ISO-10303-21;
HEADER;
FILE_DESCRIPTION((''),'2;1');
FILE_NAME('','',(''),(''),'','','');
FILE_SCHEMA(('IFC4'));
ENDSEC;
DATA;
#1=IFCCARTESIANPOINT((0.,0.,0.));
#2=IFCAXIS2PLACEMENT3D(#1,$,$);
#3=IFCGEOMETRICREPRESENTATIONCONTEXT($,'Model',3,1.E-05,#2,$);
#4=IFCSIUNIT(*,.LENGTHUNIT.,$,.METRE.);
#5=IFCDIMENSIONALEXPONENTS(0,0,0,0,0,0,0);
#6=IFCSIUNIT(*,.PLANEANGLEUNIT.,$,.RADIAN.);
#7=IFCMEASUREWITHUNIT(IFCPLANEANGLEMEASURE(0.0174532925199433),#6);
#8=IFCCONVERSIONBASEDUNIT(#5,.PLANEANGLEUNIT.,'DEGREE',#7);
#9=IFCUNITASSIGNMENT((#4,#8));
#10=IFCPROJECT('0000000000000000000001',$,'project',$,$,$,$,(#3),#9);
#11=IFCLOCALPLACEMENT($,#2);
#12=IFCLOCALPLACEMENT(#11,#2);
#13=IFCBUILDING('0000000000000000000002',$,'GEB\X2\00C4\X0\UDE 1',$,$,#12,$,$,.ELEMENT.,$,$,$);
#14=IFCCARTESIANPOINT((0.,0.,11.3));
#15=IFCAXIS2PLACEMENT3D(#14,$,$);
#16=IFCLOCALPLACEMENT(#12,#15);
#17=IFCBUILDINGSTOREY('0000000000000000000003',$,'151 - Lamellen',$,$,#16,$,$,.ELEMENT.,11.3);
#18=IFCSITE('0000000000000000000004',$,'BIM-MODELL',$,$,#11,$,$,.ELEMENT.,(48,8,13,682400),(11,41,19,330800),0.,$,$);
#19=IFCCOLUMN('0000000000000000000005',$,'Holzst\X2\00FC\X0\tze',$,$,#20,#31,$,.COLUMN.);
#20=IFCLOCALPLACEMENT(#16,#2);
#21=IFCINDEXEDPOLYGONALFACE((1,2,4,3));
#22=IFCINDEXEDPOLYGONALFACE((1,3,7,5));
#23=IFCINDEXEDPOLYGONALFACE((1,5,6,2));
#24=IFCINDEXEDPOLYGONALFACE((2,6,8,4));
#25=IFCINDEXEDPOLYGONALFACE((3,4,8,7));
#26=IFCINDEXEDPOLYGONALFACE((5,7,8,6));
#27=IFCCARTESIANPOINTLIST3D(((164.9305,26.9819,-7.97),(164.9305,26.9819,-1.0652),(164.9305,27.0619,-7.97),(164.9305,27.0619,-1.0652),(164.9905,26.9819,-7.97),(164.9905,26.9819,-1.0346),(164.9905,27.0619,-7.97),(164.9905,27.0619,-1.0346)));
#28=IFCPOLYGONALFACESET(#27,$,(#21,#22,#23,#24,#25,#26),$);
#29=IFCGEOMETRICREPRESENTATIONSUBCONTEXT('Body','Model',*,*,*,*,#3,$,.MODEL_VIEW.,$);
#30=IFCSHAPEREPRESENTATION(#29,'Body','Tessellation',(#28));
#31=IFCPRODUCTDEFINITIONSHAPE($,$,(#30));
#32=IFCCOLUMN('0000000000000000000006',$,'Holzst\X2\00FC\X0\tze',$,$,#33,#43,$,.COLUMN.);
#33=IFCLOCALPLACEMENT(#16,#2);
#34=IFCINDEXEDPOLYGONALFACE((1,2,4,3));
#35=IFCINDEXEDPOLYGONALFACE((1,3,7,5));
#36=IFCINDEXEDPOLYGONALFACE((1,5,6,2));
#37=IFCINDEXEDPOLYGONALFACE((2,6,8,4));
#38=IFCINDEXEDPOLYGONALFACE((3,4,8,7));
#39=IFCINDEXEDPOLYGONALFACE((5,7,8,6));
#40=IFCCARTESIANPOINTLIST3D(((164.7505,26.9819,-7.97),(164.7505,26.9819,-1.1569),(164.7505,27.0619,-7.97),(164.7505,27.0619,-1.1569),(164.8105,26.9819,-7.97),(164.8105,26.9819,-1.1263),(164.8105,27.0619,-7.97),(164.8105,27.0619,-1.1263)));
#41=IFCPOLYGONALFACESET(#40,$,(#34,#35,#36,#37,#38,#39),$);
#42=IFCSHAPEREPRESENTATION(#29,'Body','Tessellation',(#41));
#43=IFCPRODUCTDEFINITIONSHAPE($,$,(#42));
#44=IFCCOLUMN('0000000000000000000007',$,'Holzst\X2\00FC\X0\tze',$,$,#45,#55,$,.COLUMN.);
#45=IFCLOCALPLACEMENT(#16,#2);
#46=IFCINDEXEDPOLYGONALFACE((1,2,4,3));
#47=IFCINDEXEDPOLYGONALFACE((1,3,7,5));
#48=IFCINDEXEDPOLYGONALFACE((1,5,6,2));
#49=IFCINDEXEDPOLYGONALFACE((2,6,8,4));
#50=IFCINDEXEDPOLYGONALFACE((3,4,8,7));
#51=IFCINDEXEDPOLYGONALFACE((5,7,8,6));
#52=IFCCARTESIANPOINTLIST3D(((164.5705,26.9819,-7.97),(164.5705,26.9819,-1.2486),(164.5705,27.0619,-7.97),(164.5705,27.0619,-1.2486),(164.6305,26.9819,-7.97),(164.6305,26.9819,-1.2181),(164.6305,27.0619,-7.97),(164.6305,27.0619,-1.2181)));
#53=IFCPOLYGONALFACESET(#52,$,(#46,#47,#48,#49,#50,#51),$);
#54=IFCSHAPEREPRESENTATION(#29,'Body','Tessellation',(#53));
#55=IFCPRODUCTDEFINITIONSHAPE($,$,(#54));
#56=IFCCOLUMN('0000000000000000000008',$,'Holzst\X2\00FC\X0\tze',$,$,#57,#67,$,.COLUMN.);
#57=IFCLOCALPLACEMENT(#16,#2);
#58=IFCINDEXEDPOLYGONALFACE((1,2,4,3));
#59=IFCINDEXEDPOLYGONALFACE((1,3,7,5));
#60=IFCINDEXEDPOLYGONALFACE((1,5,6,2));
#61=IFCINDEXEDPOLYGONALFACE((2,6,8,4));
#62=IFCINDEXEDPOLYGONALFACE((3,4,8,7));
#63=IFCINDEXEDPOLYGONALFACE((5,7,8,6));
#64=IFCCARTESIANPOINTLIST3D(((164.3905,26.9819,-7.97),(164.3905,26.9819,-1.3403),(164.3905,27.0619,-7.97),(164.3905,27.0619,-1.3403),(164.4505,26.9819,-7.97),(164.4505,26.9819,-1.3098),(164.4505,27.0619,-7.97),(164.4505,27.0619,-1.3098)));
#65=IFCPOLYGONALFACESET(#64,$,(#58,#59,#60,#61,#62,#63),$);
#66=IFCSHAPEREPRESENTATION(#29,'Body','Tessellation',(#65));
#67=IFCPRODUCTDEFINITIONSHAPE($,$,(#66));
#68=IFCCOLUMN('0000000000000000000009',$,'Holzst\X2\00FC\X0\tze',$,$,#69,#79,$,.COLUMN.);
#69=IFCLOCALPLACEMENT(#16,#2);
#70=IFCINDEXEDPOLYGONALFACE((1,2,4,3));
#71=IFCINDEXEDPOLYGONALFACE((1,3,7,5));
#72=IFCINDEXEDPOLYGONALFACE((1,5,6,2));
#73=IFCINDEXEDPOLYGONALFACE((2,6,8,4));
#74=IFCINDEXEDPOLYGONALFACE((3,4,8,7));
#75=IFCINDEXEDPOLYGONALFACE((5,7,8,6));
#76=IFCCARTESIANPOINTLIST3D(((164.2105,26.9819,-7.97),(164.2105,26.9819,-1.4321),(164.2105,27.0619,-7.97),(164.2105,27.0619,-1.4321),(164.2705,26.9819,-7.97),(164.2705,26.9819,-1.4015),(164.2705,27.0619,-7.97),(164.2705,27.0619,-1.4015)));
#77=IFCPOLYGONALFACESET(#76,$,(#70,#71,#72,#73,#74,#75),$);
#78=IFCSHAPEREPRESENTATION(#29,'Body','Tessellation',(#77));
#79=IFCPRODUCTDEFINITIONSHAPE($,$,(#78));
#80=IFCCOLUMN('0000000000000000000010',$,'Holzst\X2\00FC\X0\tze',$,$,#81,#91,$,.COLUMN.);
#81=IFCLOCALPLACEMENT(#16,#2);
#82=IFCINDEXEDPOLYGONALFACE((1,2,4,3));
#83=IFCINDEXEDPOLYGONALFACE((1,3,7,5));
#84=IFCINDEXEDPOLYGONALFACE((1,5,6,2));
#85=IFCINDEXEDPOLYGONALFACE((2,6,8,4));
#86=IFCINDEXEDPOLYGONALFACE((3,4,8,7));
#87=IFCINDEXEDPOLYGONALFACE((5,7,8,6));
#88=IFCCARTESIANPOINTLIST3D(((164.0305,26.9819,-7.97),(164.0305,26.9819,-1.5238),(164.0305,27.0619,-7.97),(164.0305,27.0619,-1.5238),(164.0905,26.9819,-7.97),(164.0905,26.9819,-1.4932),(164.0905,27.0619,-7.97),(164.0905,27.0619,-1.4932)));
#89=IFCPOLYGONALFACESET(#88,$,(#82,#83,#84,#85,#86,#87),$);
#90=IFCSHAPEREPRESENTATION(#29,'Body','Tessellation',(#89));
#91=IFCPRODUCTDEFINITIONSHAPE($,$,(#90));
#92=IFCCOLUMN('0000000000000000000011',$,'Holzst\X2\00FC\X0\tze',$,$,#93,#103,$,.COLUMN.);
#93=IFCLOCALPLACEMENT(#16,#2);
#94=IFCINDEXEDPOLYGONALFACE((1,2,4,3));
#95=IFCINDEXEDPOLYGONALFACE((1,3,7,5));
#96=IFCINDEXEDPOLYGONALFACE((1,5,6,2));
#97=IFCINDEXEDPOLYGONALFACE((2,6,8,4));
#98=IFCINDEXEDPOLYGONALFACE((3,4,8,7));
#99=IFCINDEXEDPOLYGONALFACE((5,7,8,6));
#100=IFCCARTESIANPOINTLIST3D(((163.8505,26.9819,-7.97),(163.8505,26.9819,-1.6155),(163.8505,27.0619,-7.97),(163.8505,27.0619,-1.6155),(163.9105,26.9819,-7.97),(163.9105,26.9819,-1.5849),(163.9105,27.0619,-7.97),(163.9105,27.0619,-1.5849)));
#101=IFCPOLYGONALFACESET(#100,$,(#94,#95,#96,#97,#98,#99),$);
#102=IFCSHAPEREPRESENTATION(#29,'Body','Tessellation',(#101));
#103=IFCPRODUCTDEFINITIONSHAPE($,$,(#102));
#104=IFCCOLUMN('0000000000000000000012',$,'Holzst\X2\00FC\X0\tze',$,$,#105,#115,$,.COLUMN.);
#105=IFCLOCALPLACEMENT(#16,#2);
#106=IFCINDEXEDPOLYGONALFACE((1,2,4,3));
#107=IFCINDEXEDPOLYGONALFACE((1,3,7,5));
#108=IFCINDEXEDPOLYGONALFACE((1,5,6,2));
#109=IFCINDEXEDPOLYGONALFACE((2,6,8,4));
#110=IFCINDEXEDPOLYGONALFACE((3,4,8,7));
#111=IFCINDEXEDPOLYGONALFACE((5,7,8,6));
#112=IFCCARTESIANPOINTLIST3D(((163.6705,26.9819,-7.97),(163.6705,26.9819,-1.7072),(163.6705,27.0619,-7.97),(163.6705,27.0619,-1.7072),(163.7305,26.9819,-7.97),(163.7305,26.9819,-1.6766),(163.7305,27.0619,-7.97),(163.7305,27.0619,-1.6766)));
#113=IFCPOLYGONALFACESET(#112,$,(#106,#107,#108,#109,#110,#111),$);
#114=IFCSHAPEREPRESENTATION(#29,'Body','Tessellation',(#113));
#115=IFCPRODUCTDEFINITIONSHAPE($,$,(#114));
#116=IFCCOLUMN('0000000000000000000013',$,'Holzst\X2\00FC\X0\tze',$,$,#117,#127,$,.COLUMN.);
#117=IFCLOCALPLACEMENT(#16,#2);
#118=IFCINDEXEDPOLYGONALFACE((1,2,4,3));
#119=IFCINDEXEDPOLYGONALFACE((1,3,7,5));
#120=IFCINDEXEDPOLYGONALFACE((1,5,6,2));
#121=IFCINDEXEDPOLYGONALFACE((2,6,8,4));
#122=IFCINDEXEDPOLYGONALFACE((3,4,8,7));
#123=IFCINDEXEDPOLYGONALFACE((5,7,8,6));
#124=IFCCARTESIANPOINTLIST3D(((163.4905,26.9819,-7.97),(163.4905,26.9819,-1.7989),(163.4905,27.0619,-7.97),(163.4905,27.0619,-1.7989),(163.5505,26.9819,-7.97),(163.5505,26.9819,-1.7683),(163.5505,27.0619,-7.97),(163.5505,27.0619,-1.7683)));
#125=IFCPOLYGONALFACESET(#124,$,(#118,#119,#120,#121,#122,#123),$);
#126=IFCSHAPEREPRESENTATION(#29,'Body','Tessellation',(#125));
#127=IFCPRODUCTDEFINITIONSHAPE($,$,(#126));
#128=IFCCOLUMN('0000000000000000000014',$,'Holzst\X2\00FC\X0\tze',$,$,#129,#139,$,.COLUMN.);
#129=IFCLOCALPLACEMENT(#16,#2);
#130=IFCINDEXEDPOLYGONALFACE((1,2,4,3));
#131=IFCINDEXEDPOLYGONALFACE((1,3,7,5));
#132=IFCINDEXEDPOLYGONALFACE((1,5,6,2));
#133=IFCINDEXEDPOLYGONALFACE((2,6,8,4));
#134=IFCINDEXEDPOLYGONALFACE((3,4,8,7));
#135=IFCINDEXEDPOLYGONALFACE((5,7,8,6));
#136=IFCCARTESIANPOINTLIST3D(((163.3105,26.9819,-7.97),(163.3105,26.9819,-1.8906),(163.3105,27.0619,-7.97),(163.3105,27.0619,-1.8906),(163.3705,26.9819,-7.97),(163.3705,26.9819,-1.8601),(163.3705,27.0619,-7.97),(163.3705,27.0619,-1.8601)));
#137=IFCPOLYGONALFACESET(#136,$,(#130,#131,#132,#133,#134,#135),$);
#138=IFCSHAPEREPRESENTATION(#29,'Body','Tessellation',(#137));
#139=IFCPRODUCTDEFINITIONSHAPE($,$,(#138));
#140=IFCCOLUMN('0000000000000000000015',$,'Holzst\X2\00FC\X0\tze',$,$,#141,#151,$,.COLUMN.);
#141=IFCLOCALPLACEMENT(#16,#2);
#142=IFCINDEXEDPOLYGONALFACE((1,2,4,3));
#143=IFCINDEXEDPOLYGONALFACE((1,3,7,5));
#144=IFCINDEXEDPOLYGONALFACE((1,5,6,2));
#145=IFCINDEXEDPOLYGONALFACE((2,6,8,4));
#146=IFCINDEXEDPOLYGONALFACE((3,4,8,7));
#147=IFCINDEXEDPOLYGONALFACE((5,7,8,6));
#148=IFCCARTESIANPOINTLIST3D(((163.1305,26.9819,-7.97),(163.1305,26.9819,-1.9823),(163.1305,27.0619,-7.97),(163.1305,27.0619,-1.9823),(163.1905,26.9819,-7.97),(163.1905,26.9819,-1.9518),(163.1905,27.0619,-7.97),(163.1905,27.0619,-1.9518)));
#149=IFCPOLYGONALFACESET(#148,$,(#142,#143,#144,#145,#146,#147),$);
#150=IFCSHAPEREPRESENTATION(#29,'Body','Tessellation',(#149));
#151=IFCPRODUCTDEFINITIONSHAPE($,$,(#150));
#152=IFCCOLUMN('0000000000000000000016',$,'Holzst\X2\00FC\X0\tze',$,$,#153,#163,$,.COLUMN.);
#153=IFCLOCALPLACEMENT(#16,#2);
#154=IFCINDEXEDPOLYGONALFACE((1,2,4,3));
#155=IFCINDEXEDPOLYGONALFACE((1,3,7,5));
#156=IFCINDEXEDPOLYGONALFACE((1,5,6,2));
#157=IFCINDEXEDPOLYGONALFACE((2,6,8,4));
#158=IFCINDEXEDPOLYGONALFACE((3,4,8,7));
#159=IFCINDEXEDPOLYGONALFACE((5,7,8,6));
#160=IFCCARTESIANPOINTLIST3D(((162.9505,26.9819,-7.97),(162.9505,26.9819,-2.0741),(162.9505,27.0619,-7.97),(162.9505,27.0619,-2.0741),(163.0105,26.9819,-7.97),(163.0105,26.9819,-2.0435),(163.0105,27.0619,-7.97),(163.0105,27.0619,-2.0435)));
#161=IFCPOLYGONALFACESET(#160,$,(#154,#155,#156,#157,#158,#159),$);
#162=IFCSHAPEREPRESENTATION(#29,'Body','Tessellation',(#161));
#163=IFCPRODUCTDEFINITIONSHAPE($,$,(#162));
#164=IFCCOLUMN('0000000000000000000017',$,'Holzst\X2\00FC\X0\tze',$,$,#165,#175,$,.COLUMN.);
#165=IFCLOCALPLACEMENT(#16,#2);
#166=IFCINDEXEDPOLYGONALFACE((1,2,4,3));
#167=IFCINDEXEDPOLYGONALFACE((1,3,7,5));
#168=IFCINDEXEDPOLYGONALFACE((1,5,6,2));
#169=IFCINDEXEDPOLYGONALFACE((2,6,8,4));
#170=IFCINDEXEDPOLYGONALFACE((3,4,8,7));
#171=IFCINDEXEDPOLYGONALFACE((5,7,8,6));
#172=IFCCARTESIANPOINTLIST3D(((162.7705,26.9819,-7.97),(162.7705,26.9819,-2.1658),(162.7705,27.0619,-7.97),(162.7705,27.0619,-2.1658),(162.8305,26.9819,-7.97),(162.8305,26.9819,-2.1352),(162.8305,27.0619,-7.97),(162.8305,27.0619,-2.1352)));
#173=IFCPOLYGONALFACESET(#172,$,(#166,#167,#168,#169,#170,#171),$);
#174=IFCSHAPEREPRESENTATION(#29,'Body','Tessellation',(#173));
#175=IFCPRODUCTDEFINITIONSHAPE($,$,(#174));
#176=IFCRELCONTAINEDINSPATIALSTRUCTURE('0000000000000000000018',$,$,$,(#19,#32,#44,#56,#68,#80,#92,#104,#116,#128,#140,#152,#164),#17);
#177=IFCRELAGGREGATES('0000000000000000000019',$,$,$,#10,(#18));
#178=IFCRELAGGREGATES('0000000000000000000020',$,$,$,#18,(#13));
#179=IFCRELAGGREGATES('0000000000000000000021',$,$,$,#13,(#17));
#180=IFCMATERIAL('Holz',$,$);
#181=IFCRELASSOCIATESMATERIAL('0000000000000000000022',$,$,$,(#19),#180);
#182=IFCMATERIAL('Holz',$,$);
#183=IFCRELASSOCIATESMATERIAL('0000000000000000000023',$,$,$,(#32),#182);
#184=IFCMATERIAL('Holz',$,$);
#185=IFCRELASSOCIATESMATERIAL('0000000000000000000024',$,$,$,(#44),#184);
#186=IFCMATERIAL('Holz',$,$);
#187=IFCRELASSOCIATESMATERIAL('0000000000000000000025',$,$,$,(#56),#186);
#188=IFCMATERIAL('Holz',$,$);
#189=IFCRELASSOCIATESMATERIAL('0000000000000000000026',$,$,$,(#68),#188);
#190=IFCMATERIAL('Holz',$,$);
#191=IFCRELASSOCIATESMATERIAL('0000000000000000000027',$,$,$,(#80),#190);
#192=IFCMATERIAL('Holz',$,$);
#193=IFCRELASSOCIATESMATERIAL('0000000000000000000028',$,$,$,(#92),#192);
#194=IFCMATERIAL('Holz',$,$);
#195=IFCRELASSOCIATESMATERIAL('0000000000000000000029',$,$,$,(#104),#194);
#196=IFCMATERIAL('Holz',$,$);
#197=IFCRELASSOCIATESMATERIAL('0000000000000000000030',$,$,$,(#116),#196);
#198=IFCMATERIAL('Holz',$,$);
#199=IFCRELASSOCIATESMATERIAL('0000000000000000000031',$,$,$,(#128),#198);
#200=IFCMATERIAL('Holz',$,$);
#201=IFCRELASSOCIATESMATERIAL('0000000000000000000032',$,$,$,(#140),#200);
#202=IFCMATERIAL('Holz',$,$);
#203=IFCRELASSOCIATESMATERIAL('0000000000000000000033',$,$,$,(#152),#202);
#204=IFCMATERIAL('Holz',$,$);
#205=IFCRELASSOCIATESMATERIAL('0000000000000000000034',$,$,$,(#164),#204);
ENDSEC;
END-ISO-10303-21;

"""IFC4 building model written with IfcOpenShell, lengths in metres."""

from ifc_helpers import new_model, entity, si_unit, converted_unit, frame, frame_2d, origin, origin_with_axes, place, context, subcontext, project, spatial, rectangle, extrude, clip, halfspace, material, element, save


model = new_model("IFC4")

# Units and contexts
model_context = context("Model", 3, precision=1e-05, world=origin())
body_context = subcontext(model_context, "Body", "Model", "MODEL_VIEW")
ifc_project = project(units=[si_unit("LENGTHUNIT", "METRE"), converted_unit("PLANEANGLEUNIT", "DEGREE", entity("IfcPlaneAngleMeasure", 0.0174532925199433), si_unit("PLANEANGLEUNIT", "RADIAN"), dimensions=[0, 0, 0, 0, 0, 0, 0])], contexts=[model_context])

# Site, building, storey
site_placement = place(None, origin())
site = spatial("IfcSite", under=ifc_project, at=site_placement, Name="BIM-MODELL", CompositionType="ELEMENT", RefLatitude=(48, 8, 13, 682400), RefLongitude=(11, 41, 19, 330800), RefElevation=0.0)
building_placement = place(site_placement, origin())
building = spatial("IfcBuilding", under=site, at=building_placement, Name="GEBÄUDE 1", CompositionType="ELEMENT")
storey_placement = place(building_placement, frame((0.0, 0.0, 11.3)))
storey = spatial("IfcBuildingStorey", under=building, at=storey_placement, Name="151 - Lamellen", CompositionType="ELEMENT", Elevation=11.3)

# Columns
ifc_material_1 = material(Name="Holz")
column_1_placement = place(storey_placement, frame((164.9305, 26.9819, -7.97)))
element("IfcColumn", 1, at=column_1_placement, inside=storey, material=ifc_material_1, Name="Holzstütze", PredefinedType="COLUMN", context=body_context, shape_type="Clipping", body=[
    clip(extrude(rectangle(XDim=0.06, YDim=0.08, at=frame_2d((0.03, 0.04), x_axis=(1.0, 0.0))), origin_with_axes(), (0.0, 0.0, 1.0), 6.9354), halfspace(frame((0.03, 0.04, 6.9201), z_axis=(0.45399, 0.0, -0.891007), x_axis=(0.0, -1.0, 0.0)), True)),
])
ifc_material_2 = material(Name="Holz")
column_2_placement = place(storey_placement, frame((164.7505, 26.9819, -7.97)))
element("IfcColumn", 2, at=column_2_placement, inside=storey, material=ifc_material_2, Name="Holzstütze", PredefinedType="COLUMN", context=body_context, shape_type="Clipping", body=[
    clip(extrude(rectangle(XDim=0.06, YDim=0.08, at=frame_2d((0.03, 0.04), x_axis=(1.0, 0.0))), origin_with_axes(), (0.0, 0.0, 1.0), 6.8437), halfspace(frame((0.03, 0.04, 6.8284), z_axis=(0.45399, 0.0, -0.891007), x_axis=(0.0, -1.0, 0.0)), True)),
])
ifc_material_3 = material(Name="Holz")
column_3_placement = place(storey_placement, frame((164.5705, 26.9819, -7.97)))
element("IfcColumn", 3, at=column_3_placement, inside=storey, material=ifc_material_3, Name="Holzstütze", PredefinedType="COLUMN", context=body_context, shape_type="Clipping", body=[
    clip(extrude(rectangle(XDim=0.06, YDim=0.08, at=frame_2d((0.03, 0.04), x_axis=(1.0, 0.0))), origin_with_axes(), (0.0, 0.0, 1.0), 6.7519), halfspace(frame((0.03, 0.04, 6.7367), z_axis=(0.45399, 0.0, -0.891007), x_axis=(0.0, -1.0, 0.0)), True)),
])
ifc_material_4 = material(Name="Holz")
column_4_placement = place(storey_placement, frame((164.3905, 26.9819, -7.97)))
element("IfcColumn", 4, at=column_4_placement, inside=storey, material=ifc_material_4, Name="Holzstütze", PredefinedType="COLUMN", context=body_context, shape_type="Clipping", body=[
    clip(extrude(rectangle(XDim=0.06, YDim=0.08, at=frame_2d((0.03, 0.04), x_axis=(1.0, 0.0))), origin_with_axes(), (0.0, 0.0, 1.0), 6.6602), halfspace(frame((0.03, 0.04, 6.6449), z_axis=(0.45399, 0.0, -0.891007), x_axis=(0.0, -1.0, 0.0)), True)),
])
ifc_material_5 = material(Name="Holz")
column_5_placement = place(storey_placement, frame((164.2105, 26.9819, -7.97)))
element("IfcColumn", 5, at=column_5_placement, inside=storey, material=ifc_material_5, Name="Holzstütze", PredefinedType="COLUMN", context=body_context, shape_type="Clipping", body=[
    clip(extrude(rectangle(XDim=0.06, YDim=0.08, at=frame_2d((0.03, 0.04), x_axis=(1.0, 0.0))), origin_with_axes(), (0.0, 0.0, 1.0), 6.5685), halfspace(frame((0.03, 0.04, 6.5532), z_axis=(0.45399, 0.0, -0.891007), x_axis=(0.0, -1.0, 0.0)), True)),
])
ifc_material_6 = material(Name="Holz")
column_6_placement = place(storey_placement, frame((164.0305, 26.9819, -7.97)))
element("IfcColumn", 6, at=column_6_placement, inside=storey, material=ifc_material_6, Name="Holzstütze", PredefinedType="COLUMN", context=body_context, shape_type="Clipping", body=[
    clip(extrude(rectangle(XDim=0.06, YDim=0.08, at=frame_2d((0.03, 0.04), x_axis=(1.0, 0.0))), origin_with_axes(), (0.0, 0.0, 1.0), 6.4768), halfspace(frame((0.03, 0.04, 6.4615), z_axis=(0.45399, 0.0, -0.891007), x_axis=(0.0, -1.0, 0.0)), True)),
])
ifc_material_7 = material(Name="Holz")
column_7_placement = place(storey_placement, frame((163.8505, 26.9819, -7.97)))
element("IfcColumn", 7, at=column_7_placement, inside=storey, material=ifc_material_7, Name="Holzstütze", PredefinedType="COLUMN", context=body_context, shape_type="Clipping", body=[
    clip(extrude(rectangle(XDim=0.06, YDim=0.08, at=frame_2d((0.03, 0.04), x_axis=(1.0, 0.0))), origin_with_axes(), (0.0, 0.0, 1.0), 6.3851), halfspace(frame((0.03, 0.04, 6.3698), z_axis=(0.45399, 0.0, -0.891007), x_axis=(0.0, -1.0, 0.0)), True)),
])
ifc_material_8 = material(Name="Holz")
column_8_placement = place(storey_placement, frame((163.6705, 26.9819, -7.97)))
element("IfcColumn", 8, at=column_8_placement, inside=storey, material=ifc_material_8, Name="Holzstütze", PredefinedType="COLUMN", context=body_context, shape_type="Clipping", body=[
    clip(extrude(rectangle(XDim=0.06, YDim=0.08, at=frame_2d((0.03, 0.04), x_axis=(1.0, 0.0))), origin_with_axes(), (0.0, 0.0, 1.0), 6.2934), halfspace(frame((0.03, 0.04, 6.2781), z_axis=(0.45399, 0.0, -0.891007), x_axis=(0.0, -1.0, 0.0)), True)),
])
ifc_material_9 = material(Name="Holz")
column_9_placement = place(storey_placement, frame((163.4905, 26.9819, -7.97)))
element("IfcColumn", 9, at=column_9_placement, inside=storey, material=ifc_material_9, Name="Holzstütze", PredefinedType="COLUMN", context=body_context, shape_type="Clipping", body=[
    clip(extrude(rectangle(XDim=0.06, YDim=0.08, at=frame_2d((0.03, 0.04), x_axis=(1.0, 0.0))), origin_with_axes(), (0.0, 0.0, 1.0), 6.2017), halfspace(frame((0.03, 0.04, 6.1864), z_axis=(0.45399, 0.0, -0.891007), x_axis=(0.0, -1.0, 0.0)), True)),
])
ifc_material_10 = material(Name="Holz")
column_10_placement = place(storey_placement, frame((163.3105, 26.9819, -7.97)))
element("IfcColumn", 10, at=column_10_placement, inside=storey, material=ifc_material_10, Name="Holzstütze", PredefinedType="COLUMN", context=body_context, shape_type="Clipping", body=[
    clip(extrude(rectangle(XDim=0.06, YDim=0.08, at=frame_2d((0.03, 0.04), x_axis=(1.0, 0.0))), origin_with_axes(), (0.0, 0.0, 1.0), 6.1099), halfspace(frame((0.03, 0.04, 6.0947), z_axis=(0.45399, 0.0, -0.891007), x_axis=(0.0, -1.0, 0.0)), True)),
])
ifc_material_11 = material(Name="Holz")
column_11_placement = place(storey_placement, frame((163.1305, 26.9819, -7.97)))
element("IfcColumn", 11, at=column_11_placement, inside=storey, material=ifc_material_11, Name="Holzstütze", PredefinedType="COLUMN", context=body_context, shape_type="Clipping", body=[
    clip(extrude(rectangle(XDim=0.06, YDim=0.08, at=frame_2d((0.03, 0.04), x_axis=(1.0, 0.0))), origin_with_axes(), (0.0, 0.0, 1.0), 6.0182), halfspace(frame((0.03, 0.04, 6.0029), z_axis=(0.45399, 0.0, -0.891007), x_axis=(0.0, -1.0, 0.0)), True)),
])
ifc_material_12 = material(Name="Holz")
column_12_placement = place(storey_placement, frame((162.9505, 26.9819, -7.97)))
element("IfcColumn", 12, at=column_12_placement, inside=storey, material=ifc_material_12, Name="Holzstütze", PredefinedType="COLUMN", context=body_context, shape_type="Clipping", body=[
    clip(extrude(rectangle(XDim=0.06, YDim=0.08, at=frame_2d((0.03, 0.04), x_axis=(1.0, 0.0))), origin_with_axes(), (0.0, 0.0, 1.0), 5.9265), halfspace(frame((0.03, 0.04, 5.9112), z_axis=(0.45399, 0.0, -0.891007), x_axis=(0.0, -1.0, 0.0)), True)),
])
ifc_material_13 = material(Name="Holz")
column_13_placement = place(storey_placement, frame((162.7705, 26.9819, -7.97)))
element("IfcColumn", 13, at=column_13_placement, inside=storey, material=ifc_material_13, Name="Holzstütze", PredefinedType="COLUMN", context=body_context, shape_type="Clipping", body=[
    clip(extrude(rectangle(XDim=0.06, YDim=0.08, at=frame_2d((0.03, 0.04), x_axis=(1.0, 0.0))), origin_with_axes(), (0.0, 0.0, 1.0), 5.8348), halfspace(frame((0.03, 0.04, 5.8195), z_axis=(0.45399, 0.0, -0.891007), x_axis=(0.0, -1.0, 0.0)), True)),
])

save(model, "model.ifc")
